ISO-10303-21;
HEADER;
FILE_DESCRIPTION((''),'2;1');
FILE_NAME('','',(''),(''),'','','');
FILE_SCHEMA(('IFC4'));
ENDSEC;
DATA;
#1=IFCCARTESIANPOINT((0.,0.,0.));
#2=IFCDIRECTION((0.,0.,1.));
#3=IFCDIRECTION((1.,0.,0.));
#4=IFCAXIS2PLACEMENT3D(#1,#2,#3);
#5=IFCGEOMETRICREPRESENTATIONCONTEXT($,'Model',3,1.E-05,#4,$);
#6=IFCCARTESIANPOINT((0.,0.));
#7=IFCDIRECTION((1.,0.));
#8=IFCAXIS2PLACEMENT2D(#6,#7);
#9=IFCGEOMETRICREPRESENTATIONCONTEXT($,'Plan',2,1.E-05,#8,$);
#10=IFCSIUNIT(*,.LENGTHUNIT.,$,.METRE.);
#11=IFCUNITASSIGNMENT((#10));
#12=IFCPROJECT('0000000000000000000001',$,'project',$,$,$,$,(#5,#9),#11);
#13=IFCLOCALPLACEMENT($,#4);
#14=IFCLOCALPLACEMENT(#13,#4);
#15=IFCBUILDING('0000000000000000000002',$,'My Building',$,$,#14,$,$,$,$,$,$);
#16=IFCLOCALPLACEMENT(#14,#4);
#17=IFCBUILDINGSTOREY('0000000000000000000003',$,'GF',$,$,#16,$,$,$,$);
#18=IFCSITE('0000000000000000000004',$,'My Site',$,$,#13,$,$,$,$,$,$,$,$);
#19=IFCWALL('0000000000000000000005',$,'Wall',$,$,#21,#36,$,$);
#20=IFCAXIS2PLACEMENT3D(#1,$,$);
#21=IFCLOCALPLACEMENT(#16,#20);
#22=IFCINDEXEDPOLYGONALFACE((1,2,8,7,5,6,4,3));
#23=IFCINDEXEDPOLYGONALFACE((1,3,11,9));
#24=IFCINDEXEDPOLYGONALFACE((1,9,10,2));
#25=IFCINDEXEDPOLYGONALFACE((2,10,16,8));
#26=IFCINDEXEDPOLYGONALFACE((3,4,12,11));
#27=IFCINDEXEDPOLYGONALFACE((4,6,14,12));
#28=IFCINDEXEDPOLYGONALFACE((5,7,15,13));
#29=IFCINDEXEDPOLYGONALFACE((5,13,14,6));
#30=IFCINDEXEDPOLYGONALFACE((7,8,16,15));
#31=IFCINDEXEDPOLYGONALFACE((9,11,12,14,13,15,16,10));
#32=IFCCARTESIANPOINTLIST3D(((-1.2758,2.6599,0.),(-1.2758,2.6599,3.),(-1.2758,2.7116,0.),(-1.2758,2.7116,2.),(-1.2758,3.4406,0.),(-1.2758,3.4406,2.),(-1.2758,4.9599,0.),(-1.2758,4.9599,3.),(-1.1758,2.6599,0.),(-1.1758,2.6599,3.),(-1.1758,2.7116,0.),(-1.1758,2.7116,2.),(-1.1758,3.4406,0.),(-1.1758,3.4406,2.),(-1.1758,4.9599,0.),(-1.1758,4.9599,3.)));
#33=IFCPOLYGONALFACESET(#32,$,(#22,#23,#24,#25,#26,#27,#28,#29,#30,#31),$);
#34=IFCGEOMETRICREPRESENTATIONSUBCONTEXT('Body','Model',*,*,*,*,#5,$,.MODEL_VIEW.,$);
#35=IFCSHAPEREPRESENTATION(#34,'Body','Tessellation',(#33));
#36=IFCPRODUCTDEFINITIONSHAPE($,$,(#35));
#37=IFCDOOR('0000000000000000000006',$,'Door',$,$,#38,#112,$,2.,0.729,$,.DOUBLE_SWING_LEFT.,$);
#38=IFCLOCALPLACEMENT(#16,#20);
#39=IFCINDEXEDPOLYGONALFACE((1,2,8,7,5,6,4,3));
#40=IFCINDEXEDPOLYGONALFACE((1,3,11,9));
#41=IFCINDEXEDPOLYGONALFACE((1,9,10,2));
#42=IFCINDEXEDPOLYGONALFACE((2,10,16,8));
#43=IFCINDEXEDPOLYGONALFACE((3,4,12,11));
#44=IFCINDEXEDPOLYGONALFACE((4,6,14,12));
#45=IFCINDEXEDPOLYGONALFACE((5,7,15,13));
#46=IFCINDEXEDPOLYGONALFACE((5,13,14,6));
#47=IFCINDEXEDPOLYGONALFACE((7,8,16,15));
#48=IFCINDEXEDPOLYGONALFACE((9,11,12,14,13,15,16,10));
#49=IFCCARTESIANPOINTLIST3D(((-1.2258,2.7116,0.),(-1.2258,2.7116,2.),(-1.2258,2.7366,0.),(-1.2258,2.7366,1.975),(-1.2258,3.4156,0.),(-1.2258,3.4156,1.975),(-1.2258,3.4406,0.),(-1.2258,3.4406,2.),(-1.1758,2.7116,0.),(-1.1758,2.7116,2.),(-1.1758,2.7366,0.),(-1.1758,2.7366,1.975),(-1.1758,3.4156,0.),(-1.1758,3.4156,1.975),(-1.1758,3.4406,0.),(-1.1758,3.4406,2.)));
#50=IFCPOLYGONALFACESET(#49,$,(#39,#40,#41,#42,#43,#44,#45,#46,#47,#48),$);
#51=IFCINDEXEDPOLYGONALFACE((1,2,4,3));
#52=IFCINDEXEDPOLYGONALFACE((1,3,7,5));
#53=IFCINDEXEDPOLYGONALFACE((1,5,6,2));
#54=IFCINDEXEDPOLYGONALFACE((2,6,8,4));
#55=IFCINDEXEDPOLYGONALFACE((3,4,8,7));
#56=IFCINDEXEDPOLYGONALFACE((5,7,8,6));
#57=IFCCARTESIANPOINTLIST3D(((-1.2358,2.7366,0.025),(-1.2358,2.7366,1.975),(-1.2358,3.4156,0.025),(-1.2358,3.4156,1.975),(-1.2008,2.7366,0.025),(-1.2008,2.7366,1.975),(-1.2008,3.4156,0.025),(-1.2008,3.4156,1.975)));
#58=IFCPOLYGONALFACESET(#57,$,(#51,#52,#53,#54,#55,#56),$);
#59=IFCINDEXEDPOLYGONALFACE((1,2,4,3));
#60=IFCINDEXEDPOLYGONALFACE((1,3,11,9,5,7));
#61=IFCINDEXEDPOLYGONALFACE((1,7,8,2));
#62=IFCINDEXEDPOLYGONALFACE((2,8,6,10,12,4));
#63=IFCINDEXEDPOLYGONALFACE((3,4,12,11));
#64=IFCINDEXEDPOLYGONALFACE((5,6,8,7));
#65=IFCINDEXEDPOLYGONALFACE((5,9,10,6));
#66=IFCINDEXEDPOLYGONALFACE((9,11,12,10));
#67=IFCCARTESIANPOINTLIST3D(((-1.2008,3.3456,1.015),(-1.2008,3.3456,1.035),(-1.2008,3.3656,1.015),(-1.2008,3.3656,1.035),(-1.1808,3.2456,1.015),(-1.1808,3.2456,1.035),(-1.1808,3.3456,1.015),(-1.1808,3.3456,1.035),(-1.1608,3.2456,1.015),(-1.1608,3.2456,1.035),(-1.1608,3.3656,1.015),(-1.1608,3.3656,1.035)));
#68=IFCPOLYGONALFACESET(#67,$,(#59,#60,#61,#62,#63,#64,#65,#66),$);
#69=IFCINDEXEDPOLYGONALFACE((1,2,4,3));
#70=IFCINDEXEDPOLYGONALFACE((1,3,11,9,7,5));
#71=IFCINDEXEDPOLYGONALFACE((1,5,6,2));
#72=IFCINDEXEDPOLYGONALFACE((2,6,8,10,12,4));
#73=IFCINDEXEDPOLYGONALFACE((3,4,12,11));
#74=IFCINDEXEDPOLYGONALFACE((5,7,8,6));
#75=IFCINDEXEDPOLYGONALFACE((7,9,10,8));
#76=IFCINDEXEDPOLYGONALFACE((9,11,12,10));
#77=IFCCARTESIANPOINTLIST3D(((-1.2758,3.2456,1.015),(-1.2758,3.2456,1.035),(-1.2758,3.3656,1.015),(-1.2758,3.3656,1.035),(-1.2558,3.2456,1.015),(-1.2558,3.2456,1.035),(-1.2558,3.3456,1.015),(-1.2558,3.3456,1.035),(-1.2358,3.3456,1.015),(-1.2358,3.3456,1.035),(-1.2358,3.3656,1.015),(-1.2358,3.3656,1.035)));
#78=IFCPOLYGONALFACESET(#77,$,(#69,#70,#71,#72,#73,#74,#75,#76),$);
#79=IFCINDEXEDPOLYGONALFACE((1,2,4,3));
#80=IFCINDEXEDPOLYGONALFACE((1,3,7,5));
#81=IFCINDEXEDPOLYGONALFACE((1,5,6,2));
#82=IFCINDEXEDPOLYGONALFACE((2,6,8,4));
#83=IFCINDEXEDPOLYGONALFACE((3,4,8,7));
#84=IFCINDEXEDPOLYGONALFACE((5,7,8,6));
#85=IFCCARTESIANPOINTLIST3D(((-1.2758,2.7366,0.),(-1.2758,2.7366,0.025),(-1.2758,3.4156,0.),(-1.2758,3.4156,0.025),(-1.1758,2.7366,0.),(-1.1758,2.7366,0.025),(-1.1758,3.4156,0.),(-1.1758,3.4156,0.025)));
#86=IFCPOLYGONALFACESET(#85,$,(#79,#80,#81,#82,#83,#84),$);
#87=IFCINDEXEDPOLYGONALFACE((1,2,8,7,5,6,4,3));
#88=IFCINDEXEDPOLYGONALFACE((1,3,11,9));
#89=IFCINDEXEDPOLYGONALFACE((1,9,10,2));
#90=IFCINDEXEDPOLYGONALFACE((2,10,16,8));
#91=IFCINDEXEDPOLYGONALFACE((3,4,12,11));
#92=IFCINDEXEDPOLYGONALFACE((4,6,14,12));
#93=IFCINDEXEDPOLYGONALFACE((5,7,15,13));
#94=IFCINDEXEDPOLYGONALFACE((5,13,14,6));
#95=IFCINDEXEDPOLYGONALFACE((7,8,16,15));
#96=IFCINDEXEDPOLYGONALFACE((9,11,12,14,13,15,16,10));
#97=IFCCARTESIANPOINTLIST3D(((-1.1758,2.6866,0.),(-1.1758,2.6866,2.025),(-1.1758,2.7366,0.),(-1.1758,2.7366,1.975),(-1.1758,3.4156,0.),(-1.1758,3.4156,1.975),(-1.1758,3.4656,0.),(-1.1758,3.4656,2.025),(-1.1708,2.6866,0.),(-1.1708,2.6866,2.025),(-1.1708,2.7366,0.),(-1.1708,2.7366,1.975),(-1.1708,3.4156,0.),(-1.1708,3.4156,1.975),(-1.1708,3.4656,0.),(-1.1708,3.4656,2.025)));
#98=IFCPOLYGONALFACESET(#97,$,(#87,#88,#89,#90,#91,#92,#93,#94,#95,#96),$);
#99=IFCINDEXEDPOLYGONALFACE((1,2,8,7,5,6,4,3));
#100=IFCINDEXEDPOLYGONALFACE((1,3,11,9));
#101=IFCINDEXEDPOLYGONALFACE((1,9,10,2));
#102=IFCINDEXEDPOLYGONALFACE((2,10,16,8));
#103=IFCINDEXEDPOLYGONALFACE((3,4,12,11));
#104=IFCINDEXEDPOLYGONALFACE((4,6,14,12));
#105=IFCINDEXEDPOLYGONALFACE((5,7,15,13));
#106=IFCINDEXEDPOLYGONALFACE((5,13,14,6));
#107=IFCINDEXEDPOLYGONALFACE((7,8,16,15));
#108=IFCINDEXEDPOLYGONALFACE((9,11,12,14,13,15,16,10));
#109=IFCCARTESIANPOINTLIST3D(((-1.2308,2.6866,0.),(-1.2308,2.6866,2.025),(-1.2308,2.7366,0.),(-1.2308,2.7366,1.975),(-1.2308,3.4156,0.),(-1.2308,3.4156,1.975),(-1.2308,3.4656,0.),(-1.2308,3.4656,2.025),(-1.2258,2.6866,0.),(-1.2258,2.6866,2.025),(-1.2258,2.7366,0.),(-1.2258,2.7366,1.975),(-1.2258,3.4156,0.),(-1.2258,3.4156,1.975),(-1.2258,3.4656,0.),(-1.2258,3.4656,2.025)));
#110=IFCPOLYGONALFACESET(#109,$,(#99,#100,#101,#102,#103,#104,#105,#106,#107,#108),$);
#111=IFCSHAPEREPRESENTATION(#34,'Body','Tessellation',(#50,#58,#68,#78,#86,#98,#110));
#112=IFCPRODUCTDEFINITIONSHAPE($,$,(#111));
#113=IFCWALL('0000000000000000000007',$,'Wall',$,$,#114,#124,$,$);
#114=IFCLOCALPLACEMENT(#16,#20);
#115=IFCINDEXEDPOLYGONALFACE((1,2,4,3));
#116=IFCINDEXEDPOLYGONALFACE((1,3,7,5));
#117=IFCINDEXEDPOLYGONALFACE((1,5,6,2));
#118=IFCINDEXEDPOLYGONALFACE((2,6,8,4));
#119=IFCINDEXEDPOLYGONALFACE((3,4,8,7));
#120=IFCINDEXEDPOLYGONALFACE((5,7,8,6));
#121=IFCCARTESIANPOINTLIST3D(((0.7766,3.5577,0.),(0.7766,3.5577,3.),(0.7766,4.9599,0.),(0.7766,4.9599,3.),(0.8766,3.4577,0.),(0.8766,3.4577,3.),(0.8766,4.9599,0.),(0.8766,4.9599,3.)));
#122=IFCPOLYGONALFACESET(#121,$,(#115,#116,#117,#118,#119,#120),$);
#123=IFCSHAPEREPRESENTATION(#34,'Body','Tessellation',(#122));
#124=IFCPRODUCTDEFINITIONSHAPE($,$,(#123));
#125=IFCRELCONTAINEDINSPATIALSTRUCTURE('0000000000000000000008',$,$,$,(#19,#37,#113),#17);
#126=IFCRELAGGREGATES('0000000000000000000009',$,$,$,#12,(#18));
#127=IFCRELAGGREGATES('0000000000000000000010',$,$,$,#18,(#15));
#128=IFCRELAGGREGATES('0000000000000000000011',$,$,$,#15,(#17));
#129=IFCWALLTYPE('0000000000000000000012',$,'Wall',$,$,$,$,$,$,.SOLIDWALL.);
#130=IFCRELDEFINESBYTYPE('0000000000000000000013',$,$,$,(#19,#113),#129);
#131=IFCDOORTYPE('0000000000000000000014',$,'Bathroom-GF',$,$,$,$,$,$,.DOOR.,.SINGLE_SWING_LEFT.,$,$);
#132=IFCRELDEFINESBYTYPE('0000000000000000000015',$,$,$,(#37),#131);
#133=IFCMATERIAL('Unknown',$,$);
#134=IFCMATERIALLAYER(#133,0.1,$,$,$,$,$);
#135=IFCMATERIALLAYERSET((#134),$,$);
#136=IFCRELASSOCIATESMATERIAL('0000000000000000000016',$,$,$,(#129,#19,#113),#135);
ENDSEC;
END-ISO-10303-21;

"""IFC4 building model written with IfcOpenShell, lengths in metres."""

from ifc_helpers import new_model, entity, si_unit, frame, origin_with_axes, origin_2d_with_axis, place, context, subcontext, project, spatial, line, indexed_curve, outline, extrude, shape, source, transform, mapped, material, layer, layer_set, layer_usage, type_object, type_shapes, element, fill, save


model = new_model("IFC4")

# Units and contexts
model_context = context("Model", 3, precision=1e-05, world=origin_with_axes())
plan_context = context("Plan", 2, precision=1e-05, world=origin_2d_with_axis())
body_context_1 = subcontext(model_context, "Body", "Model", "MODEL_VIEW")
body_context_2 = subcontext(plan_context, "Body", "Plan", "PLAN_VIEW")
ifc_project = project(units=[si_unit("LENGTHUNIT", "METRE")], contexts=[model_context, plan_context])

# Site, building, storey
site_placement = place(None, origin_with_axes())
site = spatial("IfcSite", under=ifc_project, at=site_placement, Name="My Site")
building_placement = place(site_placement, origin_with_axes())
building = spatial("IfcBuilding", under=site, at=building_placement, Name="My Building")
storey_placement = place(building_placement, origin_with_axes())
storey = spatial("IfcBuildingStorey", under=building, at=storey_placement, Name="GF")

# Shared definitions
ifc_material_1 = material(Name="Unknown")

# Shared definitions
ifc_layer_1 = layer(ifc_material_1, 0.1)
ifc_layer_set_1 = layer_set([ifc_layer_1])
wall_type = type_object("IfcWallType", Name="Wall", PredefinedType="SOLIDWALL", material=ifc_layer_set_1)

# Wall, opening, door
ifc_layer_usage_1 = layer_usage(ifc_layer_set_1, "AXIS2", "POSITIVE", 0.0)
wall_1_placement = place(storey_placement, frame((-1.1758, 2.6599, 0.0), z_axis=(0.0, 0.0, 1.0), x_axis=(0.0, 1.0, 0.0)))
wall_1 = element("IfcWall", 1, at=wall_1_placement, inside=storey, type_object=wall_type, material=ifc_layer_usage_1, Name="Wall", context=body_context_1, shape_type="SweptSolid", body=[
    extrude(outline(indexed_curve([(0.0, 0.0), (0.0, 0.1), (2.3, 0.1), (2.3, 0.0)], segments=[line(1, 2, 3, 4, 1)])), origin_with_axes(), (0.0, 0.0, 1.0), 3.0),
])
shared_shape_1 = source(origin_with_axes(), body_context_1, "Body", "SweptSolid", [
    extrude(outline(indexed_curve([(0.0, 0.0), (0.729, 0.0), (0.729, 2.0), (0.0, 2.0)], segments=[line(1, 2, 3, 4, 1)])), frame((0.0, -0.6, 0.0), z_axis=(0.0, -1.0, 0.0), x_axis=(1.0, 0.0, 0.0)), (0.0, 0.0, -1.0), 1.2),
])
opening_1_placement = place(wall_1_placement, frame((0.0517, 0.0, 0.0), z_axis=(0.0, 0.0, 1.0), x_axis=(1.0, 0.0, 0.0)))
opening_1 = element("IfcOpeningElement", 2, at=opening_1_placement, cuts=wall_1, PredefinedType="OPENING", context=body_context_1, shape_type="MappedRepresentation", body=[
    mapped(shared_shape_1, transform((0.0, 0.0, 0.0), x_axis=(1.0, 0.0, 0.0), y_axis=(0.0, 1.0, 0.0), z_axis=(0.0, 0.0, 1.0), scale=1.0)),
])
door_type_1 = type_object("IfcDoorType", Name="Bathroom-GF", OperationType="SINGLE_SWING_LEFT", PredefinedType="DOOR")
shared_shape_2 = source(origin_with_axes(), body_context_1, "Body", "SweptSolid", [
    extrude(outline(indexed_curve([(0.0, 0.0), (0.0, 2.0), (0.729, 2.0), (0.729, 0.0), (0.704, 0.0), (0.704, 1.975), (0.025, 1.975), (0.025, 0.0)], segments=[line(1, 2, 3, 4, 5, 6, 7, 8, 1)])), frame((0.0, 0.0, 0.0), z_axis=(0.0, -1.0, 0.0), x_axis=(1.0, 0.0, 0.0)), (0.0, 0.0, -1.0), 0.05),
    extrude(outline(indexed_curve([(0.0, 0.0), (0.679, 0.0), (0.679, 0.035), (0.0, 0.035)], segments=[line(1, 2, 3, 4, 1)])), frame((0.025, 0.025, 0.025), z_axis=(0.0, 0.0, 1.0), x_axis=(1.0, 0.0, 0.0)), (0.0, 0.0, 1.0), 1.95),
    extrude(outline(indexed_curve([(0.0, 0.0), (0.0, -0.04), (-0.12, -0.04), (-0.12, -0.02), (-0.02, -0.02), (-0.02, 0.0)], segments=[line(1, 2, 3, 4, 5, 6, 1)])), frame((0.654, 0.025, 1.015), z_axis=(0.0, 0.0, 1.0), x_axis=(1.0, 0.0, 0.0)), (0.0, 0.0, 1.0), 0.02),
    extrude(outline(indexed_curve([(0.0, 0.0), (0.0, 0.04), (-0.12, 0.04), (-0.12, 0.02), (-0.02, 0.02), (-0.02, 0.0)], segments=[line(1, 2, 3, 4, 5, 6, 1)])), frame((0.654, 0.06, 1.015), z_axis=(0.0, 0.0, 1.0), x_axis=(1.0, 0.0, 0.0)), (0.0, 0.0, 1.0), 0.02),
    extrude(outline(indexed_curve([(0.0, 0.0), (0.679, 0.0), (0.679, 0.1), (0.0, 0.1)], segments=[line(1, 2, 3, 4, 1)])), frame((0.025, 0.0, 0.0), z_axis=(0.0, 0.0, 1.0), x_axis=(1.0, 0.0, 0.0)), (0.0, 0.0, 1.0), 0.025),
    extrude(outline(indexed_curve([(0.0, 0.0), (0.0, 2.025), (0.779, 2.025), (0.779, 0.0), (0.729, 0.0), (0.729, 1.975), (0.05, 1.975), (0.05, 0.0)], segments=[line(1, 2, 3, 4, 5, 6, 7, 8, 1)])), frame((-0.025, -0.005, 0.0), z_axis=(0.0, -1.0, 0.0), x_axis=(1.0, 0.0, 0.0)), (0.0, 0.0, -1.0), 0.005),
    extrude(outline(indexed_curve([(0.0, 0.0), (0.0, 2.025), (0.779, 2.025), (0.779, 0.0), (0.729, 0.0), (0.729, 1.975), (0.05, 1.975), (0.05, 0.0)], segments=[line(1, 2, 3, 4, 5, 6, 7, 8, 1)])), frame((-0.025, 0.05, 0.0), z_axis=(0.0, -1.0, 0.0), x_axis=(1.0, 0.0, 0.0)), (0.0, 0.0, -1.0), 0.005),
])
shared_shape_3 = source(origin_with_axes(), body_context_2, "Body", "Curve2D", [
    entity("IfcIndexedPolyCurve", entity("IfcCartesianPointList2D", [[0.0, 0.0], [0.025, 0.0], [0.025, 0.05], [0.0, 0.05]]), [entity("IfcLineIndex", [1, 2, 3, 4, 1])]),
    entity("IfcIndexedPolyCurve", entity("IfcCartesianPointList2D", [[0.729, 0.0], [0.704, 0.0], [0.704, 0.05], [0.729, 0.05]]), [entity("IfcLineIndex", [1, 2, 3, 4, 1])]),
    entity("IfcIndexedPolyCurve", entity("IfcCartesianPointList2D", [[0.025, 0.05], [0.025, -0.629], [0.06, -0.629]])),
    entity("IfcTrimmedCurve", entity("IfcEllipse", entity("IfcAxis2Placement2D", entity("IfcCartesianPoint", [0.06, 0.05]), entity("IfcDirection", [1.0, 0.0])), 0.644, 0.679), [entity("IfcCartesianPoint", [0.06, -0.629])], [entity("IfcCartesianPoint", [0.06, 0.729])], True, "CARTESIAN"),
    entity("IfcIndexedPolyCurve", entity("IfcCartesianPointList2D", [[0.025, 0.05], [0.06, 0.05], [0.06, 0.729], [0.025, 0.729]]), [entity("IfcLineIndex", [1, 2, 3, 4, 1])]),
])
type_shapes(door_type_1, [shared_shape_2, shared_shape_3])
door_1_placement = place(opening_1_placement, frame((0.0, 0.0, 0.0), z_axis=(0.0, 0.0, 1.0), x_axis=(1.0, 0.0, 0.0)))
door_1 = element("IfcDoor", 3, at=door_1_placement, inside=storey, type_object=door_type_1, Name="Door", OperationType="DOUBLE_SWING_LEFT", OverallHeight=2.0, OverallWidth=0.729, shapes=[
    shape(body_context_1, "Body", "MappedRepresentation", [mapped(shared_shape_2, transform((0.0, 0.0, 0.0), x_axis=(1.0, 0.0, 0.0), y_axis=(0.0, 1.0, 0.0), z_axis=(0.0, 0.0, 1.0), scale=1.0))]),
    shape(body_context_2, "Body", "MappedRepresentation", [mapped(shared_shape_3, transform((0.0, 0.0, 0.0), x_axis=(1.0, 0.0, 0.0), y_axis=(0.0, 1.0, 0.0), z_axis=(0.0, 0.0, 1.0), scale=1.0))]),
])
fill(opening_1, door_1)

# Wall
ifc_layer_usage_2 = layer_usage(ifc_layer_set_1, "AXIS2", "POSITIVE", 0.0)
wall_2_placement = place(storey_placement, frame((0.7766, 4.9599, 0.0), z_axis=(0.0, 0.0, 1.0), x_axis=(0.0, -1.0, 0.0)))
element("IfcWall", 4, at=wall_2_placement, inside=storey, type_object=wall_type, material=ifc_layer_usage_2, Name="Wall", context=body_context_1, shape_type="SweptSolid", body=[
    extrude(outline(indexed_curve([(0.0, 0.0), (0.0, 0.1), (1.5022, 0.1), (1.4022, 0.0)], segments=[line(1, 2, 3, 4, 1)])), origin_with_axes(), (0.0, 0.0, 1.0), 3.0),
])

save(model, "model.ifc")
